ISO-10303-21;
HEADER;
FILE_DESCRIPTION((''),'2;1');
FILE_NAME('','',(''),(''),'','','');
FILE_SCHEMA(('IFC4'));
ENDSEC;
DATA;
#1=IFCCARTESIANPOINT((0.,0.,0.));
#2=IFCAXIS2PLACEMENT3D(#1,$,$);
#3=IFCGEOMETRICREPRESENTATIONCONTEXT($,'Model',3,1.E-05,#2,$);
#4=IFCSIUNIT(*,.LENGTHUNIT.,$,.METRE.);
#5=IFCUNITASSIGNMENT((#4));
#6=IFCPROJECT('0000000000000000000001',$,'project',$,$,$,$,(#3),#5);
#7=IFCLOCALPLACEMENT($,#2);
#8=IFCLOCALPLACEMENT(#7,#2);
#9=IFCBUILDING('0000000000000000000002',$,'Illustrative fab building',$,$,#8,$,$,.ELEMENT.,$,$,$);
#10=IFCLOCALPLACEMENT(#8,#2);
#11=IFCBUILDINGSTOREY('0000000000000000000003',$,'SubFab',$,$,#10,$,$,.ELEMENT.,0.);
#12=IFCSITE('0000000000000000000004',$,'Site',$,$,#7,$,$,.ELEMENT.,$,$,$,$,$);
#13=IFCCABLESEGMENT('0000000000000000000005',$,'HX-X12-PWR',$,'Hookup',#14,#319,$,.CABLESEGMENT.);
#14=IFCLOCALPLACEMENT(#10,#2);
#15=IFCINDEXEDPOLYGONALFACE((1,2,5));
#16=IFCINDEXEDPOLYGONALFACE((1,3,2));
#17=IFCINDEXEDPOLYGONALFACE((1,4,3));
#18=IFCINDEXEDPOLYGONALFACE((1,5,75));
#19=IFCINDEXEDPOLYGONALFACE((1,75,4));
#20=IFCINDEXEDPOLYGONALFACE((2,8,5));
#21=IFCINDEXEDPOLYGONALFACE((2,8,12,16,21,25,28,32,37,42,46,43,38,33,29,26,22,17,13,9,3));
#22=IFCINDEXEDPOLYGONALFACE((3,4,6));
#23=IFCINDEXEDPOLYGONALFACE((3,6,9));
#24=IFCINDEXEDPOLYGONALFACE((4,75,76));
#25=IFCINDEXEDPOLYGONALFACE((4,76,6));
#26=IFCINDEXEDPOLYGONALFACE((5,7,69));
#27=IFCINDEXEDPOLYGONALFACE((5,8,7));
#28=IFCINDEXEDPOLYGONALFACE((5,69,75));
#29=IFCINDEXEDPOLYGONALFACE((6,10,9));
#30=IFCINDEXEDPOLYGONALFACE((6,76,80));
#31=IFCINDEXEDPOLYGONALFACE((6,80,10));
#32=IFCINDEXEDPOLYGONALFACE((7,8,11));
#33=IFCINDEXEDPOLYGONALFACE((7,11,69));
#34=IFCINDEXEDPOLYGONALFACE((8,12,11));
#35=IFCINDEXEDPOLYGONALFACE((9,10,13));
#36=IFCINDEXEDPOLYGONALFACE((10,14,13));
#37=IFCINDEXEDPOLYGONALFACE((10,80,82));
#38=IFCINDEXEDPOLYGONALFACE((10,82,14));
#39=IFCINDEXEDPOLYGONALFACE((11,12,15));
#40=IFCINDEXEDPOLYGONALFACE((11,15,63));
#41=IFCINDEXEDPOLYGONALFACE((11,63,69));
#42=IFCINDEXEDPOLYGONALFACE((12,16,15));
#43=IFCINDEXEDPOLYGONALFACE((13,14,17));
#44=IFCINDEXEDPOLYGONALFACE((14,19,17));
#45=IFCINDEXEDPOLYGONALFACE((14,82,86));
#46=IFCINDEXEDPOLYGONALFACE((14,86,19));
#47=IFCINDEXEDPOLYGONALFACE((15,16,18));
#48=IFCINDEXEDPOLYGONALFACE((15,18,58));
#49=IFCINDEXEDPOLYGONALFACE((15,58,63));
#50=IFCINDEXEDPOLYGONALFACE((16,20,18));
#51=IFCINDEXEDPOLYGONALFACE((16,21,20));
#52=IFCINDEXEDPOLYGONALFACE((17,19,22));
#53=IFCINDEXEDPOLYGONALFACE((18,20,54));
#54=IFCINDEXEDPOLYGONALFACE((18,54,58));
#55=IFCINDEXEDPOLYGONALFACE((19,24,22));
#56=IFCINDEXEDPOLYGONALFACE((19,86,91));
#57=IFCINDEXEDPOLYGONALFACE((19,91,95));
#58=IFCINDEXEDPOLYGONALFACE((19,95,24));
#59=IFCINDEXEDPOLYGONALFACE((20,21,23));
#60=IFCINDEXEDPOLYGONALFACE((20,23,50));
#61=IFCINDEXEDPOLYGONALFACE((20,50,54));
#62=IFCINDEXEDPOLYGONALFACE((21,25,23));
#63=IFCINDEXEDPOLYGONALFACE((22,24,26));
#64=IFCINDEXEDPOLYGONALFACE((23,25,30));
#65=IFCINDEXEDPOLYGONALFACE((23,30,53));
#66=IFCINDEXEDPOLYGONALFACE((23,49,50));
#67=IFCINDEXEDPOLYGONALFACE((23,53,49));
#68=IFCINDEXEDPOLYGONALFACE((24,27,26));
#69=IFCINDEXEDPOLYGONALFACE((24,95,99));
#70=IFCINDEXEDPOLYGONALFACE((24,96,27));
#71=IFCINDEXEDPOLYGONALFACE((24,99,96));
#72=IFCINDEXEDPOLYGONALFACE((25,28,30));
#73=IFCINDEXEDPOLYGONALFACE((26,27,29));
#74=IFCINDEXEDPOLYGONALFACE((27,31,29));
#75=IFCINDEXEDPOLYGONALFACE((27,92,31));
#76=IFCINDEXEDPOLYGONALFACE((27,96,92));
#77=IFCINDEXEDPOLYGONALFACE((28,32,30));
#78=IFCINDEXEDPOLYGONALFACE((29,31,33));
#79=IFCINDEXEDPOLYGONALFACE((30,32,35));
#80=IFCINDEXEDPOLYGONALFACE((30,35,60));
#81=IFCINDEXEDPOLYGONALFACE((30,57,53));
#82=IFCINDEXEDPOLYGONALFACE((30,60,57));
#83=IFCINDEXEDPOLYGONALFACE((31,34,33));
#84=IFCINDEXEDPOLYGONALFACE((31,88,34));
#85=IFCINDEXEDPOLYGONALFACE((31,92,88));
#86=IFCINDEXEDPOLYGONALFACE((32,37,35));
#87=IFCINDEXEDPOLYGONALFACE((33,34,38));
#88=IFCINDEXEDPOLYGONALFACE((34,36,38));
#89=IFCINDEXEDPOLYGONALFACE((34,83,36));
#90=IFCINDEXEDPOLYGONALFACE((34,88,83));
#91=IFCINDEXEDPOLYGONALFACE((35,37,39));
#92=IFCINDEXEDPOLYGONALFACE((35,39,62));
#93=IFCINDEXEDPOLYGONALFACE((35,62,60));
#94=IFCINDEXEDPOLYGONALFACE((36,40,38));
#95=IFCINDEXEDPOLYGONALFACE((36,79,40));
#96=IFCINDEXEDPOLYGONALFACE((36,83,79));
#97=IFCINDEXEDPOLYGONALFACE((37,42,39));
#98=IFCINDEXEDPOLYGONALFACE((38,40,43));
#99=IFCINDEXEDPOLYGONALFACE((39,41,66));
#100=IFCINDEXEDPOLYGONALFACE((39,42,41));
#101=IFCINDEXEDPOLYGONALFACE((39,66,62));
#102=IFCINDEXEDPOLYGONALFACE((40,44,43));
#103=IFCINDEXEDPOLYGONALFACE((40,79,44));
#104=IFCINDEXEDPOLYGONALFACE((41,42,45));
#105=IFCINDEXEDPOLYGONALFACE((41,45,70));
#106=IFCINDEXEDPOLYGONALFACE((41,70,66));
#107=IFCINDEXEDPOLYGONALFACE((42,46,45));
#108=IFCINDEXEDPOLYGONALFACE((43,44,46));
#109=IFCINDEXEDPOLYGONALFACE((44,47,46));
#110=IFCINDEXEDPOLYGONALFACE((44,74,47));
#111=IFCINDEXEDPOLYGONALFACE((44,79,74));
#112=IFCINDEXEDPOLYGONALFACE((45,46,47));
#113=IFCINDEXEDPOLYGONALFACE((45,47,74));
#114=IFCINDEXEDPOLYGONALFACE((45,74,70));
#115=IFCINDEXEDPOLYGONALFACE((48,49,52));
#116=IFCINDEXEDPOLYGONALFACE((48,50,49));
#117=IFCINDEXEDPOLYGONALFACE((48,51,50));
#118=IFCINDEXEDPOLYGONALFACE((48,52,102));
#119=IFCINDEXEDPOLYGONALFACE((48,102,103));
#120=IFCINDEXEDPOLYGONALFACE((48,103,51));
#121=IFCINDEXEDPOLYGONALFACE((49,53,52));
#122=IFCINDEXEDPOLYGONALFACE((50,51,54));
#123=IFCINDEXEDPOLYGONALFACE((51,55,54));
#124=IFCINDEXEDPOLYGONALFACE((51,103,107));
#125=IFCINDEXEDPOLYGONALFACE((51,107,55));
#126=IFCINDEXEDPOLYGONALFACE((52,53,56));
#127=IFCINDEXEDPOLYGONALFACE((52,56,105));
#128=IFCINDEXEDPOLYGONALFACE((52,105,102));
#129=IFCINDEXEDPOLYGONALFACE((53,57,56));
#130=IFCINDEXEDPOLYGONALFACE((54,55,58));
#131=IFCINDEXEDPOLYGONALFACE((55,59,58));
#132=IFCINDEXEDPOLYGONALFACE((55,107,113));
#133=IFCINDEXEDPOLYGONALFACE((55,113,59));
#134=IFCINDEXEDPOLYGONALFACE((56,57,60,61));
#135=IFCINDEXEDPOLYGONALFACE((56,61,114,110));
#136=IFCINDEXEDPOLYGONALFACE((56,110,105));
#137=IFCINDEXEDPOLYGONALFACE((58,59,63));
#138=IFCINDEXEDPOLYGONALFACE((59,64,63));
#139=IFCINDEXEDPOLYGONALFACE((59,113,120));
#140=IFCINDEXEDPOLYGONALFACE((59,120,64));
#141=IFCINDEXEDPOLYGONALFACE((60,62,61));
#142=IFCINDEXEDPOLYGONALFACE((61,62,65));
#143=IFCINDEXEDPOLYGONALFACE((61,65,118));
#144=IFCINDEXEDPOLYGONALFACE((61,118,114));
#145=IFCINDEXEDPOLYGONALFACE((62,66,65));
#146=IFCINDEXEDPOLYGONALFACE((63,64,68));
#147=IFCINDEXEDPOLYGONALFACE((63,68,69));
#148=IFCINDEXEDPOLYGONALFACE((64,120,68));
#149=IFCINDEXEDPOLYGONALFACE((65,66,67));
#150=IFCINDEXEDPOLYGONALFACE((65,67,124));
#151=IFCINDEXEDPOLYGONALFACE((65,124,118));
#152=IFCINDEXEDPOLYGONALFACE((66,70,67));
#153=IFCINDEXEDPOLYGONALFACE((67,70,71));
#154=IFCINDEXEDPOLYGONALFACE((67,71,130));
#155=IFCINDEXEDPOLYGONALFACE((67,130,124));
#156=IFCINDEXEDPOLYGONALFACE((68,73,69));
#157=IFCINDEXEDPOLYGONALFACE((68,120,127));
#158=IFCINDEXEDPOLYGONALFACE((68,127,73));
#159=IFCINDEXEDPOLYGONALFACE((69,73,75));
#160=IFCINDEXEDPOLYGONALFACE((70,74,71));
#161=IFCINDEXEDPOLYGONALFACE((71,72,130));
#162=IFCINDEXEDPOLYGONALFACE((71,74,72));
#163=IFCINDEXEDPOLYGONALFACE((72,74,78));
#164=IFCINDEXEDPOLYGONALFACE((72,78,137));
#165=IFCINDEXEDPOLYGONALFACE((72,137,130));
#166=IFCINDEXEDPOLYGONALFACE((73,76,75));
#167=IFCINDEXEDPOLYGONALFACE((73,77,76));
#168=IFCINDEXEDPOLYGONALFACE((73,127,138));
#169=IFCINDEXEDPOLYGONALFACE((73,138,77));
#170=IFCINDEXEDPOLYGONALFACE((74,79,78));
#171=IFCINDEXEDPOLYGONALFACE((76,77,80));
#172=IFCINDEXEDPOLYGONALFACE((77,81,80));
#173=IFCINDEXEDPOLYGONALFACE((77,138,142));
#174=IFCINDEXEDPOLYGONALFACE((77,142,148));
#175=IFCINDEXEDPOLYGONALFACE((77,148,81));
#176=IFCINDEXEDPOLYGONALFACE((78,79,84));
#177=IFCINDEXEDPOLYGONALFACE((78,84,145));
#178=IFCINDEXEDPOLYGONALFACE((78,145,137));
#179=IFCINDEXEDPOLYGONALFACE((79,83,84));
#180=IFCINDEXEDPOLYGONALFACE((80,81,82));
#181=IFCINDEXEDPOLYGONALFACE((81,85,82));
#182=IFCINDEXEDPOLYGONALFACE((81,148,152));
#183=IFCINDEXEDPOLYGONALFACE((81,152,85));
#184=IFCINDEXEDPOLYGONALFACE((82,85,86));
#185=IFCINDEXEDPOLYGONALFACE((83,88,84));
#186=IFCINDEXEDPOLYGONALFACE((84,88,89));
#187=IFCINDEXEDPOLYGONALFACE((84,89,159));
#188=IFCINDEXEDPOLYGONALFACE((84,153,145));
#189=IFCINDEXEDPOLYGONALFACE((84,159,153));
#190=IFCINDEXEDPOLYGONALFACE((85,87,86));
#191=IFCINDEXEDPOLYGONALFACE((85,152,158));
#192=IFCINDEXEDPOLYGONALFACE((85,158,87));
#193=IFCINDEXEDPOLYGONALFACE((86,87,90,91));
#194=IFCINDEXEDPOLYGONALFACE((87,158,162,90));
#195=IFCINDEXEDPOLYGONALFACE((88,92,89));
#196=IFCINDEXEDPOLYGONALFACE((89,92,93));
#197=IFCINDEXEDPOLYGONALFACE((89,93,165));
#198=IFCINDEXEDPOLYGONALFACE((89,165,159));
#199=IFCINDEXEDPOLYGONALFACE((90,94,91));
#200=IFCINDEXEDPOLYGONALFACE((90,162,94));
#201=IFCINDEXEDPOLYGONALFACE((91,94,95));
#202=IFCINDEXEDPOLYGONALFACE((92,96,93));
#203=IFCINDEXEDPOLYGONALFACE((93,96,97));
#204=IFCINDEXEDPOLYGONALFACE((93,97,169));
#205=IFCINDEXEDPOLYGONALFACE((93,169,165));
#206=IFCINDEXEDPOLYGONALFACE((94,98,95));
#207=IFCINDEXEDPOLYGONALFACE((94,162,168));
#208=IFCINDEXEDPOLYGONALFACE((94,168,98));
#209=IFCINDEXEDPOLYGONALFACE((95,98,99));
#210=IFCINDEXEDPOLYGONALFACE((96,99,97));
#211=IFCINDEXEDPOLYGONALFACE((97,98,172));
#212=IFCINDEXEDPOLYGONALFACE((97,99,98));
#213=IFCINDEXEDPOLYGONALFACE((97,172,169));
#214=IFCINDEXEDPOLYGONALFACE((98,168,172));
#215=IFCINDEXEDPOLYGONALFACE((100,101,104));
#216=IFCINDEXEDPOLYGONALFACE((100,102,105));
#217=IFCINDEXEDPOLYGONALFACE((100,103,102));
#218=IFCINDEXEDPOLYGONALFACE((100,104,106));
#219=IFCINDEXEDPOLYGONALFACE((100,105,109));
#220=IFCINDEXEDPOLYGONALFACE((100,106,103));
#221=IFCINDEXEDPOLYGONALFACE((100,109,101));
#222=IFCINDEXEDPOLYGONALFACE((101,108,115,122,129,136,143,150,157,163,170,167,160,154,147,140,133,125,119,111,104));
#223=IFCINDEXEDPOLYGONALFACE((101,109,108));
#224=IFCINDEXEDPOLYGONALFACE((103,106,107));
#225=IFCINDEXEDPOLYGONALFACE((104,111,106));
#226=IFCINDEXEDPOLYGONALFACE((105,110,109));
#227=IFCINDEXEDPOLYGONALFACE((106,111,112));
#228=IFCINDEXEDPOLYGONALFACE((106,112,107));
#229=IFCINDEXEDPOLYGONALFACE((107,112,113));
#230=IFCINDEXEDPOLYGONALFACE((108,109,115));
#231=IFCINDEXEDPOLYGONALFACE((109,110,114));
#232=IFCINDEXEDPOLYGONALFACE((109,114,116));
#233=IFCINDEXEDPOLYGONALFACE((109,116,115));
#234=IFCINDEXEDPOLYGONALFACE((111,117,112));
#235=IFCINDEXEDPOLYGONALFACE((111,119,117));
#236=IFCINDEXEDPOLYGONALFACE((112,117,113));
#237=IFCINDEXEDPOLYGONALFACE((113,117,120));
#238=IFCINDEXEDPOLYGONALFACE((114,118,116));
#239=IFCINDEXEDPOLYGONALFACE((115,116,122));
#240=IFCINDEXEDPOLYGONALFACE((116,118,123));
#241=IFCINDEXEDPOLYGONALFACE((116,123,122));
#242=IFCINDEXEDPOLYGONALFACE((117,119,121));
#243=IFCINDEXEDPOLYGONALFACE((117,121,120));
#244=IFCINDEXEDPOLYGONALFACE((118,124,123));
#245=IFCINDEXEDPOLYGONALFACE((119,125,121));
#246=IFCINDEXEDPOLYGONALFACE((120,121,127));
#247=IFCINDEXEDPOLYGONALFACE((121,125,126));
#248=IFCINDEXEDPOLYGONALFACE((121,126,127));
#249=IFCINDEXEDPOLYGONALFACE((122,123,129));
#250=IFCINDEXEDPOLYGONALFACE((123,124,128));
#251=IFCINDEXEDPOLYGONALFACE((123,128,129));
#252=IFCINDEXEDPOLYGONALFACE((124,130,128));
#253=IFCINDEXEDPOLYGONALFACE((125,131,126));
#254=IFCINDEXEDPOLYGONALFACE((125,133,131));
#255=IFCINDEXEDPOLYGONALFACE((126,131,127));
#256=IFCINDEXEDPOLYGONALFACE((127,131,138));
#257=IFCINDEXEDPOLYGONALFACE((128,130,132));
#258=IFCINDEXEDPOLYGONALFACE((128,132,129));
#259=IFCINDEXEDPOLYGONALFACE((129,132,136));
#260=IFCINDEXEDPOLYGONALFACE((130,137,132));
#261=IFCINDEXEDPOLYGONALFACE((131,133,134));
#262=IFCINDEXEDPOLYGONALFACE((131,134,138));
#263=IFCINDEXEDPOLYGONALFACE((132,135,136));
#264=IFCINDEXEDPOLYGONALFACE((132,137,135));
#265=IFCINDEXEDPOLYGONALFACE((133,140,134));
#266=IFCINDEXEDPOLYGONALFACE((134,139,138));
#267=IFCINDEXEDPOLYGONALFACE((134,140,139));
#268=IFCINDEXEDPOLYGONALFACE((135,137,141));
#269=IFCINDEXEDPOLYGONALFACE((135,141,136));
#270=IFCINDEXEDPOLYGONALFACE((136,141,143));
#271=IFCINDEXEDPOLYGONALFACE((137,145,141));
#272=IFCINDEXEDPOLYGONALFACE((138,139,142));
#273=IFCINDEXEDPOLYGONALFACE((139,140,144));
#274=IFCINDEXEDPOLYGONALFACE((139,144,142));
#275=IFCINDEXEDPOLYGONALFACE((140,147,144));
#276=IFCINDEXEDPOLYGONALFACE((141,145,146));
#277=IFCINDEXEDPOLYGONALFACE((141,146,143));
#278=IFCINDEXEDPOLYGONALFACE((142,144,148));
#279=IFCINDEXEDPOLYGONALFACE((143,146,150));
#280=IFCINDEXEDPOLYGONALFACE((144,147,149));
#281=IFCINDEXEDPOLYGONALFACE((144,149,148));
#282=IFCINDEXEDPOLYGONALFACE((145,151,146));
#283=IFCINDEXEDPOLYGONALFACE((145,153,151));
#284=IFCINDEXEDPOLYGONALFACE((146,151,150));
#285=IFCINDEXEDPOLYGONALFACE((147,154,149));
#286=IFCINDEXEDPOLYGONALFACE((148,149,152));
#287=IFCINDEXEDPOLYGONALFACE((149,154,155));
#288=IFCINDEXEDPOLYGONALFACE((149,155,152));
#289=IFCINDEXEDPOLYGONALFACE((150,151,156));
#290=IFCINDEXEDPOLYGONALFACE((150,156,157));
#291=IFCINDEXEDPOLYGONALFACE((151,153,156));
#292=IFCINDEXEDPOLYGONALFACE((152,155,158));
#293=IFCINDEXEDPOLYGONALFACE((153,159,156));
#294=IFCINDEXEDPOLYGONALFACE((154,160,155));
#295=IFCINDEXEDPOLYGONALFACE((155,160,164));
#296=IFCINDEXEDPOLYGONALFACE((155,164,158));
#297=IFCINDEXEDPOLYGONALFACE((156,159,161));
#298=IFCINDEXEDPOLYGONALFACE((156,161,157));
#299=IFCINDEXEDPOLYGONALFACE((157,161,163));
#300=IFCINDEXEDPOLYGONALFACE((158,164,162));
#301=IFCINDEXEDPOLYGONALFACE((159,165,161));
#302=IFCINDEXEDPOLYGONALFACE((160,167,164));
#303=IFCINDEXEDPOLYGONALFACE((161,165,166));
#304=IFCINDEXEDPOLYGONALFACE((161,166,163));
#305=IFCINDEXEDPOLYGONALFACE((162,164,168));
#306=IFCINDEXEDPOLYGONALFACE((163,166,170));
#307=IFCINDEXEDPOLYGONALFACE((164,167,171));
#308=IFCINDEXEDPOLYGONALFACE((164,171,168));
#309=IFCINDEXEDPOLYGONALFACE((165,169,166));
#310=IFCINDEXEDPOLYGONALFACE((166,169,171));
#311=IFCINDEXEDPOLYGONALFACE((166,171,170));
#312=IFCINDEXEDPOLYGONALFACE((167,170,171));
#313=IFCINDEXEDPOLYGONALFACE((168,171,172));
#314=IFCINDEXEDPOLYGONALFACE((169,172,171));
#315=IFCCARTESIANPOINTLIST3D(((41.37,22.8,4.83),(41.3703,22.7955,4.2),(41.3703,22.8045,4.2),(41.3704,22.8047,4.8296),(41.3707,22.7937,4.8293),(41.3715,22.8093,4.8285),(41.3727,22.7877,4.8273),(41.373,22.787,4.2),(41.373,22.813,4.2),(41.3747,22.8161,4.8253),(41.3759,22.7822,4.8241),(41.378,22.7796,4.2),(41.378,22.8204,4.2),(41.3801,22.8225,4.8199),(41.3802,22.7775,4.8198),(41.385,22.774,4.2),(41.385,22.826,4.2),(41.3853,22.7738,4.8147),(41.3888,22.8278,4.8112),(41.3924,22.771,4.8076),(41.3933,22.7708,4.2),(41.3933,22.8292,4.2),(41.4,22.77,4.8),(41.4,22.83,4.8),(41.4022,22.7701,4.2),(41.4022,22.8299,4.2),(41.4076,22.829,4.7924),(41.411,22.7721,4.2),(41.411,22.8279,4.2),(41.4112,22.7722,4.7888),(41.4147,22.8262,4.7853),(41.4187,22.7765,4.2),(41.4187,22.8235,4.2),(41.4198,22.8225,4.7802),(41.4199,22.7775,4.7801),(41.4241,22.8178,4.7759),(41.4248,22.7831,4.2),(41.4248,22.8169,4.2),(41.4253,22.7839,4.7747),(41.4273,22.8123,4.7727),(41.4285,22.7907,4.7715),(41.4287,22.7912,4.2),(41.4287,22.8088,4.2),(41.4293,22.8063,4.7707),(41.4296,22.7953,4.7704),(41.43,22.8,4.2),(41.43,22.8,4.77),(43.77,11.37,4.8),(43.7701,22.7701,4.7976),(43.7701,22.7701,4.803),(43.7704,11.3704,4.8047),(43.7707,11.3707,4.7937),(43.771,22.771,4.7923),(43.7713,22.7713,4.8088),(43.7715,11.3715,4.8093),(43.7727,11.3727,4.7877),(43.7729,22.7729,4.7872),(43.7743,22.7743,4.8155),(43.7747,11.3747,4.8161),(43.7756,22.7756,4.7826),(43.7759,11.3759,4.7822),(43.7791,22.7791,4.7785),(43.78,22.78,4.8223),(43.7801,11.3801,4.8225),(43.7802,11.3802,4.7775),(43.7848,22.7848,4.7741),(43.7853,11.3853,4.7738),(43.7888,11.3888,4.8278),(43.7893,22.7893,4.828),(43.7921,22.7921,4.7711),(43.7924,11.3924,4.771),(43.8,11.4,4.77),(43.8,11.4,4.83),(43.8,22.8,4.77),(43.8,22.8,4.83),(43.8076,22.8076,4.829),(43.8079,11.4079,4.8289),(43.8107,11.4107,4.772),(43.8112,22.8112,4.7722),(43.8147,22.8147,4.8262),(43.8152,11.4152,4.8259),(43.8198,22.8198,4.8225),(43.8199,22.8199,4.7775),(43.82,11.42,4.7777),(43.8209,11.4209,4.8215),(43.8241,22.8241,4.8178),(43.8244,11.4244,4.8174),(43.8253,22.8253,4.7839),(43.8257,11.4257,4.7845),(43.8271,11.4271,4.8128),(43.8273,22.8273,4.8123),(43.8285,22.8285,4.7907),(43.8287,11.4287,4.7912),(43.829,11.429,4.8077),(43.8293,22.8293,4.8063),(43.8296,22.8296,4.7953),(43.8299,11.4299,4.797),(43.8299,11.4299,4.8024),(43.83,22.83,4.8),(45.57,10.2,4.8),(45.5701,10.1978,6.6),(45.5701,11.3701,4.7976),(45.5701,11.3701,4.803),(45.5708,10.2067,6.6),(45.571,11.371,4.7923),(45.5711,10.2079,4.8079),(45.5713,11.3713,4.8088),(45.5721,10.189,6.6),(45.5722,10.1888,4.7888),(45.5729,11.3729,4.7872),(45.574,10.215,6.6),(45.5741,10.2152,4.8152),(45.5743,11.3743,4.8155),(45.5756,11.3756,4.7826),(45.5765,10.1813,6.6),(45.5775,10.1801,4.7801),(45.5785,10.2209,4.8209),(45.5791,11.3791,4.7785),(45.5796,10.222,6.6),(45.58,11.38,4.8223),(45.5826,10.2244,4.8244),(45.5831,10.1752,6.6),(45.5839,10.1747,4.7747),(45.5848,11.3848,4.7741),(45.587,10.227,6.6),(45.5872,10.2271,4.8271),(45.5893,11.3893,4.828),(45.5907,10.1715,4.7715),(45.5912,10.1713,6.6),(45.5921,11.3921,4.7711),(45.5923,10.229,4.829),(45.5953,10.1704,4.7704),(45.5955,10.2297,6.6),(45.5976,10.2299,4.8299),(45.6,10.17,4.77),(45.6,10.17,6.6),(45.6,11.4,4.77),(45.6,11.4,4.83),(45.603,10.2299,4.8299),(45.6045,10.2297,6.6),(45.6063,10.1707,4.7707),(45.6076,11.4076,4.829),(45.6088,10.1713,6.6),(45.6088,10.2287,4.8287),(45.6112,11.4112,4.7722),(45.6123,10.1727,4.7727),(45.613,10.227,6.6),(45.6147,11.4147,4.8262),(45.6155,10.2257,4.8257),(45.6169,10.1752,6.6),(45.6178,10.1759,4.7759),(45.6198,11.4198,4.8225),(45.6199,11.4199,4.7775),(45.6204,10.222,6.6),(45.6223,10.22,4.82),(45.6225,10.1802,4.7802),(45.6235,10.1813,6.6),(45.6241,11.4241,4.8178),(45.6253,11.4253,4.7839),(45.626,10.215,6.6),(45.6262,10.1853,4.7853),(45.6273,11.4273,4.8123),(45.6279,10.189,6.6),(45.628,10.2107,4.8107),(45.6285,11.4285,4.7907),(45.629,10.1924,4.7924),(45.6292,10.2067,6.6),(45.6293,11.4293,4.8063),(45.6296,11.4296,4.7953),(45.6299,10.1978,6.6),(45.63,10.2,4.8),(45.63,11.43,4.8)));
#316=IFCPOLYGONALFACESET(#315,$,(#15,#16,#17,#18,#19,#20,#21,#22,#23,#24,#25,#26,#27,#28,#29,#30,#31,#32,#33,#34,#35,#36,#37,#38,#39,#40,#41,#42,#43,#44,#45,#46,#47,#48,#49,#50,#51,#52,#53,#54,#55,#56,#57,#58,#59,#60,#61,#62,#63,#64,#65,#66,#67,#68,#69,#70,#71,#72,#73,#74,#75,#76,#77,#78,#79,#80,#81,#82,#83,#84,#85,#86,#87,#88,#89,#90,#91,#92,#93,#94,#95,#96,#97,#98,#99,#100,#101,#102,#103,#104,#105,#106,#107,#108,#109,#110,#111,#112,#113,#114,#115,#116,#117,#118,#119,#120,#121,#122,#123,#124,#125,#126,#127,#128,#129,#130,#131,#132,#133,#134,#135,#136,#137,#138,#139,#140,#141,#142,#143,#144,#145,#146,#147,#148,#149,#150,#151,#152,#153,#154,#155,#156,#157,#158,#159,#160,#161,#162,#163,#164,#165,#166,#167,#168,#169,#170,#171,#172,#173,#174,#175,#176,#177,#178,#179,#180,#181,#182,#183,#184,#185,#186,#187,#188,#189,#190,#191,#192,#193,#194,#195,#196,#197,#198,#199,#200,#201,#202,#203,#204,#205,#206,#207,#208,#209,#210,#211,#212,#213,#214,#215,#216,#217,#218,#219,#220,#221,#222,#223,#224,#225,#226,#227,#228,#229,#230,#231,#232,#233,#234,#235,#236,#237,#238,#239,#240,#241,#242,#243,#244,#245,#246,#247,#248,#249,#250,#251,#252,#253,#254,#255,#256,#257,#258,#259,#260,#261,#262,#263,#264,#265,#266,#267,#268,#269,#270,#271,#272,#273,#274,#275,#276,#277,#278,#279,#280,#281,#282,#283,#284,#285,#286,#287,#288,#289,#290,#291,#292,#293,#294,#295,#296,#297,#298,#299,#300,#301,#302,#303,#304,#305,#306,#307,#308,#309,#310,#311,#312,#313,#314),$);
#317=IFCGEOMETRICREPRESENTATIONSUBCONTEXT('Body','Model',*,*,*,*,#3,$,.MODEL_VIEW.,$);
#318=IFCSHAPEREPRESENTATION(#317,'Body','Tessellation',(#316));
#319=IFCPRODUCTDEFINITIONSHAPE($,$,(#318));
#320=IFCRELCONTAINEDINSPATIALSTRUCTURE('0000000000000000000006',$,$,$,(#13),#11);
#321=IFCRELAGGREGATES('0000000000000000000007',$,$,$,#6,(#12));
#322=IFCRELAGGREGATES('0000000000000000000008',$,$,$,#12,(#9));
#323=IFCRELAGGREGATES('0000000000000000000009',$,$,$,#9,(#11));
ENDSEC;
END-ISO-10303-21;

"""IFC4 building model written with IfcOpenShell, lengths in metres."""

from ifc_helpers import new_model, entity, si_unit, origin, place, context, subcontext, project, spatial, element, save


model = new_model("IFC4")

# Units and contexts
model_context = context("Model", 3, precision=1e-05, world=origin())
body_context = subcontext(model_context, "Body", "Model", "MODEL_VIEW")
ifc_project = project(units=[si_unit("LENGTHUNIT", "METRE")], contexts=[model_context])

# Site, building, storey
site_placement = place(None, origin())
site = spatial("IfcSite", under=ifc_project, at=site_placement, Name="Site", CompositionType="ELEMENT")
building_placement = place(site_placement, origin())
building = spatial("IfcBuilding", under=site, at=building_placement, Name="Illustrative fab building", CompositionType="ELEMENT")
storey_placement = place(building_placement, origin())
storey = spatial("IfcBuildingStorey", under=building, at=storey_placement, Name="SubFab", CompositionType="ELEMENT", Elevation=0.0)

# Cable segment
cable_segment_1_placement = place(storey_placement, origin())
element("IfcCableSegment", 1, at=cable_segment_1_placement, inside=storey, Name="HX-X12-PWR", ObjectType="Hookup", PredefinedType="CABLESEGMENT", context=body_context, shape_type="AdvancedSweptSolid", body=[
    entity("IfcSweptDiskSolid", entity("IfcPolyline", [entity("IfcCartesianPoint", [41.4, 22.8, 4.2]), entity("IfcCartesianPoint", [41.4, 22.8, 4.8]), entity("IfcCartesianPoint", [43.8, 22.8, 4.8]), entity("IfcCartesianPoint", [43.8, 11.4, 4.8]), entity("IfcCartesianPoint", [45.6, 11.4, 4.8]), entity("IfcCartesianPoint", [45.6, 10.2, 4.8]), entity("IfcCartesianPoint", [45.6, 10.2, 6.6])]), 0.03),
])

save(model, "model.ifc")
